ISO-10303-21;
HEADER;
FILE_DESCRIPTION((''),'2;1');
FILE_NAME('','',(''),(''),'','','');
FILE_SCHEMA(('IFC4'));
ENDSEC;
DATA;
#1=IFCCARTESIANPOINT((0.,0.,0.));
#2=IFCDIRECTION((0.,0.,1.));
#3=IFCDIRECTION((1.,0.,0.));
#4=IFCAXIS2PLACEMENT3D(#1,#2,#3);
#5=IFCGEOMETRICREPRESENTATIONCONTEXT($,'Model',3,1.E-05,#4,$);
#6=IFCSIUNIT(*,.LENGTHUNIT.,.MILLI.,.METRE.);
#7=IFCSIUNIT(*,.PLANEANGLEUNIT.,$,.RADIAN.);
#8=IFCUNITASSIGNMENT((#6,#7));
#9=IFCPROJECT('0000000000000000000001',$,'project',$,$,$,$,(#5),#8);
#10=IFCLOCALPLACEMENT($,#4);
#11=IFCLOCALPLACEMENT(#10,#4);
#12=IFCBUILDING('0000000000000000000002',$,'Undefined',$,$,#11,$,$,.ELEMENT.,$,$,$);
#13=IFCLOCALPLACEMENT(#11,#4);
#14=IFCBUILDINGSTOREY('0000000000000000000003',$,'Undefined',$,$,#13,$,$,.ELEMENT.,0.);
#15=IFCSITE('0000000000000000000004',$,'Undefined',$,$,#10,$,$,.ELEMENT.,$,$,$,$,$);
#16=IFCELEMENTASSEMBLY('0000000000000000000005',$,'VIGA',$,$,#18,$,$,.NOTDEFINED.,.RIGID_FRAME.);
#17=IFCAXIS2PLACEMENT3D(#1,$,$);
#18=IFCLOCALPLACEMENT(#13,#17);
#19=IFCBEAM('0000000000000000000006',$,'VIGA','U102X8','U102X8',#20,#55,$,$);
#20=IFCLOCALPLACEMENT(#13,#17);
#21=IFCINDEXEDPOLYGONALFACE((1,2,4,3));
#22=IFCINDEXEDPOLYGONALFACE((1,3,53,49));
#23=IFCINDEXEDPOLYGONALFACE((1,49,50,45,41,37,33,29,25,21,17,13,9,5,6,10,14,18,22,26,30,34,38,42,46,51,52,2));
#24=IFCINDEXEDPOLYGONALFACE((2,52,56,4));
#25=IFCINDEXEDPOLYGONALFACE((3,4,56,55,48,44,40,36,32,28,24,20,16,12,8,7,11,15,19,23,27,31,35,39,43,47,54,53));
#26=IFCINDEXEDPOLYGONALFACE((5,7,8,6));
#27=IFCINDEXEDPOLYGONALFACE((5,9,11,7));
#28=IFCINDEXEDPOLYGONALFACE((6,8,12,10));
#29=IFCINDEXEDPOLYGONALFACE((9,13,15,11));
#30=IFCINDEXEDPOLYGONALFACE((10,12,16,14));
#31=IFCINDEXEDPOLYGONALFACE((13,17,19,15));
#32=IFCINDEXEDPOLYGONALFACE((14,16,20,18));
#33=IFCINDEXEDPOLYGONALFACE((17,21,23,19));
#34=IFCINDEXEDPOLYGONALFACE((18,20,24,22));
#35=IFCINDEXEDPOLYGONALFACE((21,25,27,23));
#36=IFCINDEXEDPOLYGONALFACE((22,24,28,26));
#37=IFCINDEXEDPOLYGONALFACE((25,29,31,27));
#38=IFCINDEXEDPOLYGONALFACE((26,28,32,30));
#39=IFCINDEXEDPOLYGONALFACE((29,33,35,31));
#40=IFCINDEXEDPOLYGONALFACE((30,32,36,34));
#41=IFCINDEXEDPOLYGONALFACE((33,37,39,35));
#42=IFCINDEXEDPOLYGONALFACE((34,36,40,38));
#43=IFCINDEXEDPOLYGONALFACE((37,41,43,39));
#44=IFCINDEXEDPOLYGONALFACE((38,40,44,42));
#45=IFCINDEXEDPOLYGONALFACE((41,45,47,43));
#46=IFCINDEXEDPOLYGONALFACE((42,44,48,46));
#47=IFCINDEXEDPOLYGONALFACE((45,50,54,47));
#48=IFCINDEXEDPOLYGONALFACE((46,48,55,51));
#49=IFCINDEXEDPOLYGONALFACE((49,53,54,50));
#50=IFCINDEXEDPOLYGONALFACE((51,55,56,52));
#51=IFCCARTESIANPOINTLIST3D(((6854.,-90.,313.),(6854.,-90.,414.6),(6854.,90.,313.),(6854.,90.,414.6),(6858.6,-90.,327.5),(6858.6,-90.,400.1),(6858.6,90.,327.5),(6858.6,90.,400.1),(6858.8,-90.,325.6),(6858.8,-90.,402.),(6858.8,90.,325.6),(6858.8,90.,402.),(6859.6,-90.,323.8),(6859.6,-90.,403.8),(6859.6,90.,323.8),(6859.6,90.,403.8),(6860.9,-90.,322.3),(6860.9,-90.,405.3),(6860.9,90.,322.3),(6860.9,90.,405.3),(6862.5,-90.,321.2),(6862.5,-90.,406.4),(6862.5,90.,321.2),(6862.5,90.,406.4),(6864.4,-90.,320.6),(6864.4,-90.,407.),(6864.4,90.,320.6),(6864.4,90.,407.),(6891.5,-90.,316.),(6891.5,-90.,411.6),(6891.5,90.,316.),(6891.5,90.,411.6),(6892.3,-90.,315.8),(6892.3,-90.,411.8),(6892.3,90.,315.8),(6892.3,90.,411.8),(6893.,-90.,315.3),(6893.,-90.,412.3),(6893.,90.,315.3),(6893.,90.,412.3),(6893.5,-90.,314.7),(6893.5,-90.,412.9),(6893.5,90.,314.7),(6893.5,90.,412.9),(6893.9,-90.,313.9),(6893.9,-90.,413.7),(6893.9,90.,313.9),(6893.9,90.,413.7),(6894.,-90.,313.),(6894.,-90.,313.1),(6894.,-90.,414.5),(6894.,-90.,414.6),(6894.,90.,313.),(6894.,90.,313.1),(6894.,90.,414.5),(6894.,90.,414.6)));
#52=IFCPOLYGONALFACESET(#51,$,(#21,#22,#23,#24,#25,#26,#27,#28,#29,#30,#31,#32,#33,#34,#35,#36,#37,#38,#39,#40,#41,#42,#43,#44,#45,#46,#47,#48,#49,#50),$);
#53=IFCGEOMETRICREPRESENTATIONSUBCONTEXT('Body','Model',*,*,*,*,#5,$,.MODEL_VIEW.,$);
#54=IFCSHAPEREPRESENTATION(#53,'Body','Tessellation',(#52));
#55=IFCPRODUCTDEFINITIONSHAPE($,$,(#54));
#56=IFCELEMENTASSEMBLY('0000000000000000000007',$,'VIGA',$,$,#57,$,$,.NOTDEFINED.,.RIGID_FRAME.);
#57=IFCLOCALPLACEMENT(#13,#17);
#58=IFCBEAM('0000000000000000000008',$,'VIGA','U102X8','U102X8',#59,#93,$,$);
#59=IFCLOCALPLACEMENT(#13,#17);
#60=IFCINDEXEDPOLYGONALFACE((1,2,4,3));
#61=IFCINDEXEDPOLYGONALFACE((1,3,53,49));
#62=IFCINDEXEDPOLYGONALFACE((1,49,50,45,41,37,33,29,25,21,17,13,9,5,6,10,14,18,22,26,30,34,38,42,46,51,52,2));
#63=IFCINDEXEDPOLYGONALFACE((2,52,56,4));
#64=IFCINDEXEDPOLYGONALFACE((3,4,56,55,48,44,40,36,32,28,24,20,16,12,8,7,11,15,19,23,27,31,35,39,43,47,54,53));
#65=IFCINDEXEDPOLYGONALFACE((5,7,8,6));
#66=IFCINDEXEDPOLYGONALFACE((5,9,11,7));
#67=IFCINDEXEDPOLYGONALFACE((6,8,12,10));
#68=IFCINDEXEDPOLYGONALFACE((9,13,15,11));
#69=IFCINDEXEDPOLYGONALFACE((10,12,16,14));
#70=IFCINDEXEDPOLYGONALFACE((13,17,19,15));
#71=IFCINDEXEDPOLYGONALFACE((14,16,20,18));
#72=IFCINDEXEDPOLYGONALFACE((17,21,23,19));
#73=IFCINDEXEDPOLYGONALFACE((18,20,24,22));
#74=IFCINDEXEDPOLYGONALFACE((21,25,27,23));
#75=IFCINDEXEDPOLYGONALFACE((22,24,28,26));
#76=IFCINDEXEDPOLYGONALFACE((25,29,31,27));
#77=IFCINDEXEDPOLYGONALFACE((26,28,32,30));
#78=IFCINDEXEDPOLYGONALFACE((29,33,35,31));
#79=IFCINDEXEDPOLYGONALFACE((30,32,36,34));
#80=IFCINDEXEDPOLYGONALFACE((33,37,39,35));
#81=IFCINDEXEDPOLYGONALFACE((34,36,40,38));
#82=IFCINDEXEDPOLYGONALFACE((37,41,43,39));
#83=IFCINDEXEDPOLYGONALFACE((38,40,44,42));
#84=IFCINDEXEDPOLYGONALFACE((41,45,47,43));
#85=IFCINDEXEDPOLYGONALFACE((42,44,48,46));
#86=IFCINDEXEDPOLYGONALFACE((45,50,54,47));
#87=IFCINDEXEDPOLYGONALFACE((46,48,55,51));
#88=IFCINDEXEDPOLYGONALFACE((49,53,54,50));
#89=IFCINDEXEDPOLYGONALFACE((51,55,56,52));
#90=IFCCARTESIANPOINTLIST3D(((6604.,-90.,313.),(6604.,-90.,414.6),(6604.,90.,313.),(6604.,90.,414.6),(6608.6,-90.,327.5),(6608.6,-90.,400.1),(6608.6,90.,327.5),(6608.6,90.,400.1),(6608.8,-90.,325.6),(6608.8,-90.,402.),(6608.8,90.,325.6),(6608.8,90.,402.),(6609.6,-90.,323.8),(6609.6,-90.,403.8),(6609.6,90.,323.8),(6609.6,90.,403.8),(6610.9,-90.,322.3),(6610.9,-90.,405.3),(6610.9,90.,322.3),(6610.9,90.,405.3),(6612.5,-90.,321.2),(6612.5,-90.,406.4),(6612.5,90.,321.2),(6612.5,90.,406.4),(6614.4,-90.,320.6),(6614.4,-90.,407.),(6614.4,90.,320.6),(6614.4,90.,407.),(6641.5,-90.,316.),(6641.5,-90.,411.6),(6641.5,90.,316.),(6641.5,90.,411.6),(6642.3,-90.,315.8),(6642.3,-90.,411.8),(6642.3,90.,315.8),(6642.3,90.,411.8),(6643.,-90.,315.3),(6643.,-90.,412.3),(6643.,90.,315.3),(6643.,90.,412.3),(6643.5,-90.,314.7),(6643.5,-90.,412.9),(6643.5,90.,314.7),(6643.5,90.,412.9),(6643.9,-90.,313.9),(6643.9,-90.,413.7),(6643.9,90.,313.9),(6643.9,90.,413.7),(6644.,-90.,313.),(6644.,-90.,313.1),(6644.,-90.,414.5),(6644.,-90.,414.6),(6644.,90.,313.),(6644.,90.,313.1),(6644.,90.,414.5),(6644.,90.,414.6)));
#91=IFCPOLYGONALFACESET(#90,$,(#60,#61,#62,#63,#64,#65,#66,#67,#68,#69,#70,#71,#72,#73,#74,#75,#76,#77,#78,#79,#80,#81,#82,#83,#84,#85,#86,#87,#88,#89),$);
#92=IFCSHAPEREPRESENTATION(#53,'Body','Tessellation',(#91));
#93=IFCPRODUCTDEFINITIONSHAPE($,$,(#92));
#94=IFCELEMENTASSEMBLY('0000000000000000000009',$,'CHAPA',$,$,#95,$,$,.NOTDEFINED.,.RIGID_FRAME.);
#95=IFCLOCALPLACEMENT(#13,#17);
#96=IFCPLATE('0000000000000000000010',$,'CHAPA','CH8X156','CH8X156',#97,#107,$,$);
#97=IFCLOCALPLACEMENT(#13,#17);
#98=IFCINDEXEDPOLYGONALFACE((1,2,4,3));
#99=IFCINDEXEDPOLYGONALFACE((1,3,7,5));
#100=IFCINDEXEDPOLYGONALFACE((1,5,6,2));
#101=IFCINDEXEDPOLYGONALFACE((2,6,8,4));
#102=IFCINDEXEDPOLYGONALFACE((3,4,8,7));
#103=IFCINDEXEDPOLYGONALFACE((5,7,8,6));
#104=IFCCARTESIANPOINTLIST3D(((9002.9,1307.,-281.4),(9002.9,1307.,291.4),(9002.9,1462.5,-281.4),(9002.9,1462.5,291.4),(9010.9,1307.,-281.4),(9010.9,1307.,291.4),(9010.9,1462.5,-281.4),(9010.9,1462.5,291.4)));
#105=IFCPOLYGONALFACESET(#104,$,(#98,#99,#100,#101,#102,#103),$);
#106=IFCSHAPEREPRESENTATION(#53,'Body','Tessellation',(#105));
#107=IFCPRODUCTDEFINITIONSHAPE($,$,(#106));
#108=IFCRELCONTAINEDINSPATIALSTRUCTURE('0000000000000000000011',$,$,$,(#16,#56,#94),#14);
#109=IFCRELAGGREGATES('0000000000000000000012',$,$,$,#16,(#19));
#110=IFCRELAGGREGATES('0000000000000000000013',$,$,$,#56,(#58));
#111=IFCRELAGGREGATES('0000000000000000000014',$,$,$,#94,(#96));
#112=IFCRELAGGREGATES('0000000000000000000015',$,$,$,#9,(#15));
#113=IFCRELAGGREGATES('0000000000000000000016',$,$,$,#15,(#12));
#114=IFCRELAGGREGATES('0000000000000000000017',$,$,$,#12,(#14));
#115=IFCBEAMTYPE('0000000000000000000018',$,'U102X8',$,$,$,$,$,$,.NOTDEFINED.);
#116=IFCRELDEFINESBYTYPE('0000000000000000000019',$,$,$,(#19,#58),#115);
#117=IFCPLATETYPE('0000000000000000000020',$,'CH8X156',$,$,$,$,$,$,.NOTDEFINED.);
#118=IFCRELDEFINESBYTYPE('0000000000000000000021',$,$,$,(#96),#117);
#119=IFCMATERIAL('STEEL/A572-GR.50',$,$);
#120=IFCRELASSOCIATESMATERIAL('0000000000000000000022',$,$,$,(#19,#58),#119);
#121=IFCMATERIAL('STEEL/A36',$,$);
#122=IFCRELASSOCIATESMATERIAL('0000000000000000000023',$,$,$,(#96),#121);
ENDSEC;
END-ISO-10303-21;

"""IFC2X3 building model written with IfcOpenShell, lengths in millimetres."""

from ifc_helpers import new_model, si_unit, frame, origin_with_axes, origin_2d_with_axis, place, context, subcontext, project, spatial, polyline, u_section, outline, extrude, material, type_object, element, aggregate, save


model = new_model("IFC2X3")

# Units and contexts
model_context = context("Model", 3, precision=1e-05, world=origin_with_axes())
body_context = subcontext(model_context, "Body", "Model", "MODEL_VIEW")
ifc_project = project(units=[si_unit("LENGTHUNIT", "METRE", prefix="MILLI"), si_unit("PLANEANGLEUNIT", "RADIAN")], contexts=[model_context])

# Site, building, storey
site_placement = place(None, origin_with_axes())
site = spatial("IfcSite", under=ifc_project, at=site_placement, Name="Undefined", CompositionType="ELEMENT")
building_placement = place(site_placement, origin_with_axes())
building = spatial("IfcBuilding", under=site, at=building_placement, Name="Undefined", CompositionType="ELEMENT")
storey_placement = place(building_placement, origin_with_axes())
storey = spatial("IfcBuildingStorey", under=building, at=storey_placement, Name="Undefined", CompositionType="ELEMENT", Elevation=0.0)

# Element assemblies, beams
ifc_material_1 = material(Name="STEEL/A572-GR.50")
beam_type_1 = type_object("IfcBeamType", Name="U102X8", PredefinedType="NOTDEFINED")
assembly_1_placement = place(storey_placement, origin_with_axes())
assembly_1 = element("IfcElementAssembly", 1, at=assembly_1_placement, inside=storey, Name="VIGA", AssemblyPlace="NOTDEFINED", PredefinedType="RIGID_FRAME")
beam_1_placement = place(assembly_1_placement, frame((6874.0, -90.0, 363.8), z_axis=(0.0, 0.0, 1.0), x_axis=(0.0, 1.0, 0.0)))
beam_1 = element("IfcBeam", 2, at=beam_1_placement, type_object=beam_type_1, material=ifc_material_1, Name="VIGA", Description="U102X8", ObjectType="U102X8", context=body_context, shape_type="SweptSolid", body=[
    extrude(u_section(Depth=101.6, FlangeWidth=40.0, WebThickness=4.6, FlangeThickness=6.0, FilletRadius=7.0, EdgeRadius=3.0, FlangeSlope=0.16839, at=origin_2d_with_axis()), frame((180.0, 0.0, 0.0), z_axis=(-1.0, 0.0, 0.0), x_axis=(0.0, -1.0, 0.0)), (0.0, 0.0, 1.0), 180.0),
])
aggregate(assembly_1, [beam_1])
assembly_2_placement = place(storey_placement, origin_with_axes())
assembly_2 = element("IfcElementAssembly", 3, at=assembly_2_placement, inside=storey, Name="VIGA", AssemblyPlace="NOTDEFINED", PredefinedType="RIGID_FRAME")
beam_2_placement = place(assembly_2_placement, frame((6624.0, -90.0, 363.8), z_axis=(0.0, 0.0, 1.0), x_axis=(0.0, 1.0, 0.0)))
beam_2 = element("IfcBeam", 4, at=beam_2_placement, type_object=beam_type_1, material=ifc_material_1, Name="VIGA", Description="U102X8", ObjectType="U102X8", context=body_context, shape_type="SweptSolid", body=[
    extrude(u_section(Depth=101.6, FlangeWidth=40.0, WebThickness=4.6, FlangeThickness=6.0, FilletRadius=7.0, EdgeRadius=3.0, FlangeSlope=0.16839, at=origin_2d_with_axis()), frame((180.0, 0.0, 0.0), z_axis=(-1.0, 0.0, 0.0), x_axis=(0.0, -1.0, 0.0)), (0.0, 0.0, 1.0), 180.0),
])
aggregate(assembly_2, [beam_2])

# Element assembly, plate
assembly_3_placement = place(storey_placement, origin_with_axes())
assembly_3 = element("IfcElementAssembly", 5, at=assembly_3_placement, inside=storey, Name="CHAPA", AssemblyPlace="NOTDEFINED", PredefinedType="RIGID_FRAME")
ifc_material_2 = material(Name="STEEL/A36")
plate_type = type_object("IfcPlateType", Name="CH8X156", PredefinedType="NOTDEFINED")
plate_placement = place(assembly_3_placement, frame((9006.9, 1462.5, 291.4), z_axis=(1.0, 0.0, 0.0), x_axis=(0.0, -1.0, 0.0)))
plate = element("IfcPlate", 6, at=plate_placement, type_object=plate_type, material=ifc_material_2, Name="CHAPA", Description="CH8X156", ObjectType="CH8X156", context=body_context, shape_type="SweptSolid", body=[
    extrude(outline(polyline([(0.0, 0.0), (155.5, 0.0), (155.5, 572.8), (0.0, 572.8), (0.0, 0.0)])), frame((0.0, 0.0, -4.0), z_axis=(0.0, 0.0, 1.0), x_axis=(1.0, 0.0, 0.0)), (0.0, 0.0, 1.0), 8.0),
])
aggregate(assembly_3, [plate])

save(model, "model.ifc")
